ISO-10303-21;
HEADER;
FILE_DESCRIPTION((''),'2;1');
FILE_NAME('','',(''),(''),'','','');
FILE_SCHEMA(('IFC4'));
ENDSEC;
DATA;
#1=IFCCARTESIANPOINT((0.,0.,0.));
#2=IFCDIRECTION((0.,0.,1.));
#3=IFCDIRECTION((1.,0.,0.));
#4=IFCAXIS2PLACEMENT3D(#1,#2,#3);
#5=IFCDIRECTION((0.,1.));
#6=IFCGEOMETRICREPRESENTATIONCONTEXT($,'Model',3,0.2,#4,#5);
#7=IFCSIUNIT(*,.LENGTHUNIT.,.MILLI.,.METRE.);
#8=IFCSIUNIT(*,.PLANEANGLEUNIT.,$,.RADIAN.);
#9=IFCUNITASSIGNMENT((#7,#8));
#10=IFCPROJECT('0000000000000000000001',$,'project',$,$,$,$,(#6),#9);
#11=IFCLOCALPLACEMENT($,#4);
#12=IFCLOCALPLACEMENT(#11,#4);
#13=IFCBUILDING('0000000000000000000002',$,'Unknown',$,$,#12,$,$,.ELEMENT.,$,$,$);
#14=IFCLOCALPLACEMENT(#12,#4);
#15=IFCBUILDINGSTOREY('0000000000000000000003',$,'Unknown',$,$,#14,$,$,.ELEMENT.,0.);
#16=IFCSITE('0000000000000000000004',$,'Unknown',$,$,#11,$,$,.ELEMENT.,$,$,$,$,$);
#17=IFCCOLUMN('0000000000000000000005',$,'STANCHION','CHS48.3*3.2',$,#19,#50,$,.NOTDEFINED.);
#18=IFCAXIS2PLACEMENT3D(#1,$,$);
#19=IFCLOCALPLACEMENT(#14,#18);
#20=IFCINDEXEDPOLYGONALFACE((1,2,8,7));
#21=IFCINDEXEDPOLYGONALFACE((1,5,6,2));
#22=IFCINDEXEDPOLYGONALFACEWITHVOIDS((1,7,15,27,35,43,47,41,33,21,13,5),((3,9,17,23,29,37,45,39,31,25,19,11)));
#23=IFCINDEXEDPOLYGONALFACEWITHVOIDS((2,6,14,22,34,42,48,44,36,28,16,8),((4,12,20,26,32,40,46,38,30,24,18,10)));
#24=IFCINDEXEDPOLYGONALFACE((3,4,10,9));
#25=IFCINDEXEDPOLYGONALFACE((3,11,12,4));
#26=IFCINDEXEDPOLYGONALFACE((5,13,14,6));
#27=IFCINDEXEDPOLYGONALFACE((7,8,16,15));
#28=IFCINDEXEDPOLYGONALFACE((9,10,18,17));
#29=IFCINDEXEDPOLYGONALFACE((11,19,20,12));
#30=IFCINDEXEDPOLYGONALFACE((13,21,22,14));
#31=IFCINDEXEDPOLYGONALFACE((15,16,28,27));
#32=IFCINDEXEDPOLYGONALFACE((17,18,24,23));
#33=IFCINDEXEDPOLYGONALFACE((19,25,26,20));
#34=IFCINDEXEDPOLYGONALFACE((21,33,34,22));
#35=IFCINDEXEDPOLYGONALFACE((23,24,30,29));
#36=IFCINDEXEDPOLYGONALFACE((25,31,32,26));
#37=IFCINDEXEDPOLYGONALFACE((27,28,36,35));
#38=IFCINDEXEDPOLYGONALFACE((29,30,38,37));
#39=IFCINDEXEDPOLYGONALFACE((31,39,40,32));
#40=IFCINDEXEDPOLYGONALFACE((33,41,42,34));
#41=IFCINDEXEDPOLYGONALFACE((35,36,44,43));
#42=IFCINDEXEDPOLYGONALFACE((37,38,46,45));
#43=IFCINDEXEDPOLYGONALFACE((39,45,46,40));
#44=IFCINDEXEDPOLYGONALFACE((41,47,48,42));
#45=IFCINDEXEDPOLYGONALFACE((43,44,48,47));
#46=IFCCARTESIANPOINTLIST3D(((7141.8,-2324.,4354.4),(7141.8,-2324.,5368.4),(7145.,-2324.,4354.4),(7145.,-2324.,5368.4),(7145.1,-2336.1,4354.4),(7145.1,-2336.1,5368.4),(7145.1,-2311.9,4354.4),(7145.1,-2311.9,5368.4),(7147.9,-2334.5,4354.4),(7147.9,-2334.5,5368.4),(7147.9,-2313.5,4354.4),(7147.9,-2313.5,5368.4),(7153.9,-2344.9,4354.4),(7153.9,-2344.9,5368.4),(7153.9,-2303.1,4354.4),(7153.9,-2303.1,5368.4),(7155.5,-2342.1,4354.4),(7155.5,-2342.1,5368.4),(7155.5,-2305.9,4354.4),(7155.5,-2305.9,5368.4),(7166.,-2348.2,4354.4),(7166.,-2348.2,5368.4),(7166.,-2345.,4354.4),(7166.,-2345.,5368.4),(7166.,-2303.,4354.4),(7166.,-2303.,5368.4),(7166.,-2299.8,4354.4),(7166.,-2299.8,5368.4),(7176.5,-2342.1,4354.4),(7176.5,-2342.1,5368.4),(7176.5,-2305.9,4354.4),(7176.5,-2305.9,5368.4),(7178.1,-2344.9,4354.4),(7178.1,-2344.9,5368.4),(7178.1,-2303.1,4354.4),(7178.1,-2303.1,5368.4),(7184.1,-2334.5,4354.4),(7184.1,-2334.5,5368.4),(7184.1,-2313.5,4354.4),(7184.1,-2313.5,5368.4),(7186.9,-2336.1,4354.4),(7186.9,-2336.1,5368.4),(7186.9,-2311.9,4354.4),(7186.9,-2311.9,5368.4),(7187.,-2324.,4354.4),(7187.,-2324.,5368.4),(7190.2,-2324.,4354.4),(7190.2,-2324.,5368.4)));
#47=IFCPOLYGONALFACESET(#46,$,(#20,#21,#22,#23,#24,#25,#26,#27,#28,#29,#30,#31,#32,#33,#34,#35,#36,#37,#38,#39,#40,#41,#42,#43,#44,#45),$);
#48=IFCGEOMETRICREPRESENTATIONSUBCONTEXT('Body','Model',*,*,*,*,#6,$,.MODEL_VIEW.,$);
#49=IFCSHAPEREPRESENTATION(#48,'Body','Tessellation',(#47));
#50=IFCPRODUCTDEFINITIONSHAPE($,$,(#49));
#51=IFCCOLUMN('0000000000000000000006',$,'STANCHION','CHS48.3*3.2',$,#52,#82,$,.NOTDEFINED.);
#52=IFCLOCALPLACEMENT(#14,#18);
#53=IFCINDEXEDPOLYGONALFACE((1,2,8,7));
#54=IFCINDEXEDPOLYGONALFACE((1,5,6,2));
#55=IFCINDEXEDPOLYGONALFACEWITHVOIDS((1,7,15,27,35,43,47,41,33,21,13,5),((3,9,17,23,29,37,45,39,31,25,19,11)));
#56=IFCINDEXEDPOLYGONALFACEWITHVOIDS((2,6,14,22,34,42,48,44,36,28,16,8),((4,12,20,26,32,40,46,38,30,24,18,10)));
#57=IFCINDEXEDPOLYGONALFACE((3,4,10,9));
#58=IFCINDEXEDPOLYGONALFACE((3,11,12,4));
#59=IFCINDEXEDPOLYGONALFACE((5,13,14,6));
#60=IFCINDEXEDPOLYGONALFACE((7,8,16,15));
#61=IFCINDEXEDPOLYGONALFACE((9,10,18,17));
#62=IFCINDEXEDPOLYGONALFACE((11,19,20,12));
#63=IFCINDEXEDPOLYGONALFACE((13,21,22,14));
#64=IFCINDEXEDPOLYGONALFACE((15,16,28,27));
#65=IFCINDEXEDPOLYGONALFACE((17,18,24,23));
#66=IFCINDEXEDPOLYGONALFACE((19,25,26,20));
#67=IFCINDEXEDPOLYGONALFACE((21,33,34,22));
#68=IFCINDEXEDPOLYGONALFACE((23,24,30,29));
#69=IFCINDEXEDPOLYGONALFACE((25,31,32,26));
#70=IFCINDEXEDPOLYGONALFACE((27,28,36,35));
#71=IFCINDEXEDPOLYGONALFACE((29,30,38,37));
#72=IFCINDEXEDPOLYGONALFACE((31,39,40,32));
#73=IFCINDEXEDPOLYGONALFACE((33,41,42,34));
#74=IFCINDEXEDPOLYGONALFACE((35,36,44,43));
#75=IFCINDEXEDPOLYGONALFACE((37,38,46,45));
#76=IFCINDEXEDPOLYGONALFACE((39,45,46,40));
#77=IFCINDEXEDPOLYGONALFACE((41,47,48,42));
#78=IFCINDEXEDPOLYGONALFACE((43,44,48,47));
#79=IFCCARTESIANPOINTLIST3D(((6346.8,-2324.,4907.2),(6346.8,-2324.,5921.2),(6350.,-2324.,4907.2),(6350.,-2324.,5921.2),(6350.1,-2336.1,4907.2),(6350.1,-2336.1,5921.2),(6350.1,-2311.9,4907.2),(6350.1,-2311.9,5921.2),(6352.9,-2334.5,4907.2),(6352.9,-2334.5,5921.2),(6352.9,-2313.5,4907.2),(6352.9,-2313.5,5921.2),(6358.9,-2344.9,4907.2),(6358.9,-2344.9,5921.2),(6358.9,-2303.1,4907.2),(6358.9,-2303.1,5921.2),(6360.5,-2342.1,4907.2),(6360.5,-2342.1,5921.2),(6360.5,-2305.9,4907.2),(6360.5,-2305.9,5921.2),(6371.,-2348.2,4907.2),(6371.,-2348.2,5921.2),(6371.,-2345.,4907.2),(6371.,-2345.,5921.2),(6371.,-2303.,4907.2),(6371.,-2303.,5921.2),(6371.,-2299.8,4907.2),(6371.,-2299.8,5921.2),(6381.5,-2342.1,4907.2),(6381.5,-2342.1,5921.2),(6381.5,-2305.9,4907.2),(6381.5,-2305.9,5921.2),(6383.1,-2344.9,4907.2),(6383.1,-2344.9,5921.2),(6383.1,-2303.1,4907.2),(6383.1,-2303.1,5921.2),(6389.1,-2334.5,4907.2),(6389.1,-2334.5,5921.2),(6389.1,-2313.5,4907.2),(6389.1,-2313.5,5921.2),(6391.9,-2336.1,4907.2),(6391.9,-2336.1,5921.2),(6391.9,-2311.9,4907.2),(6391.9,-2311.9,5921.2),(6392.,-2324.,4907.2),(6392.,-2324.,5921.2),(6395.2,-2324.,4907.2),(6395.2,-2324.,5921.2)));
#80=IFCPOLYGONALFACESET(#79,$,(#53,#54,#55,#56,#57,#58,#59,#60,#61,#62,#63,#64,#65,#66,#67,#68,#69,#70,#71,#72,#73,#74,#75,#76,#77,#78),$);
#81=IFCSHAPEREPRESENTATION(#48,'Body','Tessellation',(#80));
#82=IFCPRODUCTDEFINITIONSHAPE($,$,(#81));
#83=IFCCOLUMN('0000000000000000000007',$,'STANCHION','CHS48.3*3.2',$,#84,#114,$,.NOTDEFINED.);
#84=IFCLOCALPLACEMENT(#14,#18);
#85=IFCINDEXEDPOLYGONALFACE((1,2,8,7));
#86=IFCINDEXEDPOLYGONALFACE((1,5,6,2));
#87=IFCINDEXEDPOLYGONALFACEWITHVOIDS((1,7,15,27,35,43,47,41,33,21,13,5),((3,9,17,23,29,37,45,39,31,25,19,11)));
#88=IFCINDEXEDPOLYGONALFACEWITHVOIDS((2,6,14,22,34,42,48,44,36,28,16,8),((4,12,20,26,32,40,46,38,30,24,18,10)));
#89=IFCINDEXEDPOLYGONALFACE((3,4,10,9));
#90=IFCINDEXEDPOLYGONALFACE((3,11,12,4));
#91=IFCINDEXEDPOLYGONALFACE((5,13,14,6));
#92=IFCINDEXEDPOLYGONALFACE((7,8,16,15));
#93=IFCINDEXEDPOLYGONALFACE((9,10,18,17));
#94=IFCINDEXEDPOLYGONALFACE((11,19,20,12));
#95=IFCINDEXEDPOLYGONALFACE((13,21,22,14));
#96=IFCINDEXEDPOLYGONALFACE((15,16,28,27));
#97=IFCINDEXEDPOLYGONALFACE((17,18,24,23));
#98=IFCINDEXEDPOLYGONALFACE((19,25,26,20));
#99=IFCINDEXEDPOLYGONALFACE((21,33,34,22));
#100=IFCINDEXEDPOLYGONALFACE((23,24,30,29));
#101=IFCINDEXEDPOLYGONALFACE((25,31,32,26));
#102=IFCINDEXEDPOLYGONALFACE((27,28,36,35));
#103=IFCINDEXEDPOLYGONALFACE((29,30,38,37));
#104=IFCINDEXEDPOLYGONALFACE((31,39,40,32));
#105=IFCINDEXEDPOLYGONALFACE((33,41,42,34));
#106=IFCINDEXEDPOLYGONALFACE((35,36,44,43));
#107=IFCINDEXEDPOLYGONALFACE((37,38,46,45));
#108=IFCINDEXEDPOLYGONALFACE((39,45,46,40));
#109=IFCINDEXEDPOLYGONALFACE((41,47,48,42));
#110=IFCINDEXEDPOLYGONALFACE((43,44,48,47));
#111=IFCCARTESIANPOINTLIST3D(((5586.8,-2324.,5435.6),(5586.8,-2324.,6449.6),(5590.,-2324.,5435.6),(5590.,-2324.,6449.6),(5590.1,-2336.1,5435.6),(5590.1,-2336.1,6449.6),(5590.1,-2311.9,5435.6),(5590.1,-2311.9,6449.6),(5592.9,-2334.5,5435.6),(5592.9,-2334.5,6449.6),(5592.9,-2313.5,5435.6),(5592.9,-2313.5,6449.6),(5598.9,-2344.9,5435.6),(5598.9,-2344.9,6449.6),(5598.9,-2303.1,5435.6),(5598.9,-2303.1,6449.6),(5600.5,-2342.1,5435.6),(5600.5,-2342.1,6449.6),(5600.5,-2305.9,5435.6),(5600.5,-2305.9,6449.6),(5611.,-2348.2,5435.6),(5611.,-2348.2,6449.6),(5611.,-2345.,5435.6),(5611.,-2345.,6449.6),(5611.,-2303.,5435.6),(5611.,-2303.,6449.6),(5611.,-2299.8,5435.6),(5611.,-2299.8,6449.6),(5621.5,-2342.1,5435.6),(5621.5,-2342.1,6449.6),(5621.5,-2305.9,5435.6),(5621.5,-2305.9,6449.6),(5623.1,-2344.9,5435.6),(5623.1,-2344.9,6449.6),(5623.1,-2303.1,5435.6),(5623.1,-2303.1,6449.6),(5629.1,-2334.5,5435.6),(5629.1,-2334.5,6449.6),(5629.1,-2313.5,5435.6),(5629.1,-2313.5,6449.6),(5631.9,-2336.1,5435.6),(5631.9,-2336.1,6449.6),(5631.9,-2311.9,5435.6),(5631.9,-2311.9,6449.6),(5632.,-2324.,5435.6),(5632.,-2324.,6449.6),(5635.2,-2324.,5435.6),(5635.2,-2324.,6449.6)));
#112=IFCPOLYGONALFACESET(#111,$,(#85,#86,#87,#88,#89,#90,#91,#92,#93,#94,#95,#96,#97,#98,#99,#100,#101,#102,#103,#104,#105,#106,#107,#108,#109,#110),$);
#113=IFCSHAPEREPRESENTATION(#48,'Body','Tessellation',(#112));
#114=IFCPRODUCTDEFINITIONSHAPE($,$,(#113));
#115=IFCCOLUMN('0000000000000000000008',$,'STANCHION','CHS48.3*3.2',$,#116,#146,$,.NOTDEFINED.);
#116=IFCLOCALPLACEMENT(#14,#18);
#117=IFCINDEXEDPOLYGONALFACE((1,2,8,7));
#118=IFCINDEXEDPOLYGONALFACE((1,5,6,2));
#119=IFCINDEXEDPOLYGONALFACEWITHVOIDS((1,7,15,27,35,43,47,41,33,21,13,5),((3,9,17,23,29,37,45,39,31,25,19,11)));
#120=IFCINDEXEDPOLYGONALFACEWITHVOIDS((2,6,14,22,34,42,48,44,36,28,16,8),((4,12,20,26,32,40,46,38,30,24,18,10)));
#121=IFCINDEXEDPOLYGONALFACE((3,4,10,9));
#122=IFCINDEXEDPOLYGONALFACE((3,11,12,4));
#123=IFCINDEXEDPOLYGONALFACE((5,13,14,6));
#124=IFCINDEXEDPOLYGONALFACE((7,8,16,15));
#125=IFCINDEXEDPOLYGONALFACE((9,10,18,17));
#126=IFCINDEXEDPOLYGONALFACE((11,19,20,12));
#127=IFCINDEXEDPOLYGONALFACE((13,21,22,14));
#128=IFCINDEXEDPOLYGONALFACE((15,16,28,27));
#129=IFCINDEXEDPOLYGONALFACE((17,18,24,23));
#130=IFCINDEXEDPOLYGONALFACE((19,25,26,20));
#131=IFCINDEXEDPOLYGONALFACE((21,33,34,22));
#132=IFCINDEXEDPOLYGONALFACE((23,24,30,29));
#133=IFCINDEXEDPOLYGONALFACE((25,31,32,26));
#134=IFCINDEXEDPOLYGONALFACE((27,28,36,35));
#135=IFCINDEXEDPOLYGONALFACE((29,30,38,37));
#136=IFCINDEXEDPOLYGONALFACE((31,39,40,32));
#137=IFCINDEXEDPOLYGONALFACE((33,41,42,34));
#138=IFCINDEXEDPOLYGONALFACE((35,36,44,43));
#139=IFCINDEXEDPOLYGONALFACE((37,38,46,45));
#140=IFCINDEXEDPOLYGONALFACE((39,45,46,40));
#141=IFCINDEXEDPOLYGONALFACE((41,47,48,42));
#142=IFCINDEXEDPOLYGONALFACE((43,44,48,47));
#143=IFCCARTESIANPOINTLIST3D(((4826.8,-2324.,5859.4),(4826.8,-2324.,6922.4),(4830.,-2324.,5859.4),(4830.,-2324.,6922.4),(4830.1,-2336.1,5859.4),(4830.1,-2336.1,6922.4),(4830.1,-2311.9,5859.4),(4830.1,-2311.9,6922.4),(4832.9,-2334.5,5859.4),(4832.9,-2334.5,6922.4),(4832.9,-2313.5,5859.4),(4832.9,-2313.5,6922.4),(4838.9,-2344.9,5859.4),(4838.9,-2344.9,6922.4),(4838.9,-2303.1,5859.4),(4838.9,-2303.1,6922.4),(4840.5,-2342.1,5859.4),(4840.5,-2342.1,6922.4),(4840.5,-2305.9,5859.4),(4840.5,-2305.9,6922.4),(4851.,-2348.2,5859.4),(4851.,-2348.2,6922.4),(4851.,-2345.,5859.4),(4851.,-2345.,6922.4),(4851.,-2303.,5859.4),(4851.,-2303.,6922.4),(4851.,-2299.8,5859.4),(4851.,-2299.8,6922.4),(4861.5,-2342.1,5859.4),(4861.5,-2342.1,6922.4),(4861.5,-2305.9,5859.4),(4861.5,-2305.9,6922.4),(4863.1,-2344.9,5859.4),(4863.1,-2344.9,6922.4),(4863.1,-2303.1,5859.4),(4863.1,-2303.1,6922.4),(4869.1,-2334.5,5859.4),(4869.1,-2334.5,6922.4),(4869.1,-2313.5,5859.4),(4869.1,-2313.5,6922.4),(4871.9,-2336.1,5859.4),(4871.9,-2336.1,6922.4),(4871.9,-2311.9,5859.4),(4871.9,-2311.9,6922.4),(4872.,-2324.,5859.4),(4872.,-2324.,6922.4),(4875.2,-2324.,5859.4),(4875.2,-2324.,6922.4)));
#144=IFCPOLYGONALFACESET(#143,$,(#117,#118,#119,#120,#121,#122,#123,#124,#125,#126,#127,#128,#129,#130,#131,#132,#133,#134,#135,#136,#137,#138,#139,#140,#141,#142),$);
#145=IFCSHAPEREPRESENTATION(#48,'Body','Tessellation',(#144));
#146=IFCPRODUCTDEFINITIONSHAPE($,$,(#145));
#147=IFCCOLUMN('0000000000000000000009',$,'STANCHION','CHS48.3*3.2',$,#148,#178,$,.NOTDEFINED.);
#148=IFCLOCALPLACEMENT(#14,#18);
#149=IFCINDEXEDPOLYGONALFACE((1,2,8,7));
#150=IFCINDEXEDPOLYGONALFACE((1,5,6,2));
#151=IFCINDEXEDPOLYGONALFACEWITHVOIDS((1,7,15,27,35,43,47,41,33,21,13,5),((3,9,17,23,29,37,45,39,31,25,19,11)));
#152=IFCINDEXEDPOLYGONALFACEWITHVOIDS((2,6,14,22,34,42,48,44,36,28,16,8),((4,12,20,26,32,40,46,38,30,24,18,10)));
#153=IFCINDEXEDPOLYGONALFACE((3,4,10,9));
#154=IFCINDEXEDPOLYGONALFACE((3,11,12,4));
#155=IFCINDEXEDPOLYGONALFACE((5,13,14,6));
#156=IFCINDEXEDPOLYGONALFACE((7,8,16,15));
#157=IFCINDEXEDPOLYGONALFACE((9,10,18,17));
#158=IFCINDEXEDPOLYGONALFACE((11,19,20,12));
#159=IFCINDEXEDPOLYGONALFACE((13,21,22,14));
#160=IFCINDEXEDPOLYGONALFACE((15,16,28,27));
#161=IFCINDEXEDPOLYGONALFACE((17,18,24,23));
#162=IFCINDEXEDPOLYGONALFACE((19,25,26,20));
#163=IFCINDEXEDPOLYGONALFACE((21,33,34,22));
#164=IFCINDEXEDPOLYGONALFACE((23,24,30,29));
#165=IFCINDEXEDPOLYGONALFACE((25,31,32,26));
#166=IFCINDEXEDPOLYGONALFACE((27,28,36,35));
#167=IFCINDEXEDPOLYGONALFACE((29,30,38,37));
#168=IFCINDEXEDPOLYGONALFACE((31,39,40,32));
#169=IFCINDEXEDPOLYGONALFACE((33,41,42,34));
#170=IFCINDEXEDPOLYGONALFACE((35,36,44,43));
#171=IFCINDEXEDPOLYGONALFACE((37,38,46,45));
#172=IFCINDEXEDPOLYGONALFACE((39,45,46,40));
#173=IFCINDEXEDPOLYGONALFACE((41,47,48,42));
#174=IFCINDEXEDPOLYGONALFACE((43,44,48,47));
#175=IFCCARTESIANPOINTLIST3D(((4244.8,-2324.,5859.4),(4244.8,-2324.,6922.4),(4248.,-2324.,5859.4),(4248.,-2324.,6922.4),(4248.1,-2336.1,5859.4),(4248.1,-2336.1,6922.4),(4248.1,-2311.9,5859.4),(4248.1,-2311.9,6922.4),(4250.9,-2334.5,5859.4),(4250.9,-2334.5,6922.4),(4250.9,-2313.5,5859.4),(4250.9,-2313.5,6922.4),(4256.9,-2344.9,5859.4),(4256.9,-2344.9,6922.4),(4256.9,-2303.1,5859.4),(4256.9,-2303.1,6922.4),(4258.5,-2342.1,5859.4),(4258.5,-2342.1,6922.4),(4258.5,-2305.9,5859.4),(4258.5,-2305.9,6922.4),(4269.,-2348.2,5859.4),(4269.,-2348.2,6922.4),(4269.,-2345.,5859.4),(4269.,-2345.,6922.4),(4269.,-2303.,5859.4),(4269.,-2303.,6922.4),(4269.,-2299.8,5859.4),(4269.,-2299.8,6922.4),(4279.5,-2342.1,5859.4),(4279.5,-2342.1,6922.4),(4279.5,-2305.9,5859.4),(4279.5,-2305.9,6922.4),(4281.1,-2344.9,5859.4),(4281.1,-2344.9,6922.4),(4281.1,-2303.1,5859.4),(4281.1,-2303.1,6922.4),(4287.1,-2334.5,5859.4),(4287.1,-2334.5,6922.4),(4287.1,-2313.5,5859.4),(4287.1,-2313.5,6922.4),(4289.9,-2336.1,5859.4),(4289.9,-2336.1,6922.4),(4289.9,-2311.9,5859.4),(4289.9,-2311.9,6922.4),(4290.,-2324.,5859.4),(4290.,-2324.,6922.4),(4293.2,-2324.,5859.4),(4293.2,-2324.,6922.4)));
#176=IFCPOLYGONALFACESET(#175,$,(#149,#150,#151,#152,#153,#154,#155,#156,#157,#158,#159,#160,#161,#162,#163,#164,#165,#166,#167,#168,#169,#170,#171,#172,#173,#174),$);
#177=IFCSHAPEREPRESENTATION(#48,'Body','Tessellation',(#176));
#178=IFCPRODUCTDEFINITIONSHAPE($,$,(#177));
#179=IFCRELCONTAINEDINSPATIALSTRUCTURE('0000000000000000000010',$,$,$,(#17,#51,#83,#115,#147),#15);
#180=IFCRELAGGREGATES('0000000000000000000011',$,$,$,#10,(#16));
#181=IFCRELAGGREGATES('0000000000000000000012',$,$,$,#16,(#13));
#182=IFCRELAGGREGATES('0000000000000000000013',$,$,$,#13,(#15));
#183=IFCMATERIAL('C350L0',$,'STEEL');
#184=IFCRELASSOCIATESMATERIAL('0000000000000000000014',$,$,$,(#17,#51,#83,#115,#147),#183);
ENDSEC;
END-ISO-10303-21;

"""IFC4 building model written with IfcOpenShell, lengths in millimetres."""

from ifc_helpers import new_model, si_unit, direction, frame, origin_with_axes, place, context, subcontext, project, spatial, line, indexed_curve, outline, extrude, material, element, save


model = new_model("IFC4")

# Units and contexts
model_context = context("Model", 3, precision=0.2, world=origin_with_axes(), true_north=direction((0.0, 1.0)))
body_context = subcontext(model_context, "Body", "Model", "MODEL_VIEW")
ifc_project = project(units=[si_unit("LENGTHUNIT", "METRE", prefix="MILLI"), si_unit("PLANEANGLEUNIT", "RADIAN")], contexts=[model_context])

# Site, building, storey
site_placement = place(None, origin_with_axes())
site = spatial("IfcSite", under=ifc_project, at=site_placement, Name="Unknown", CompositionType="ELEMENT")
building_placement = place(site_placement, origin_with_axes())
building = spatial("IfcBuilding", under=site, at=building_placement, Name="Unknown", CompositionType="ELEMENT")
storey_placement = place(building_placement, origin_with_axes())
storey = spatial("IfcBuildingStorey", under=building, at=storey_placement, Name="Unknown", CompositionType="ELEMENT", Elevation=0.0)

# Columns
ifc_material_1 = material(Name="C350L0", Category="STEEL")
for number, where, z_axis, x_axis, name in (
    (1, (7166.0, -2324.0, 4354.4), (-1.0, 0.0, 0.0), (0.0, 0.0, 1.0), "STANCHION"),
    (2, (6371.0, -2324.0, 4907.2), (-1.0, 0.0, 0.0), (0.0, 0.0, 1.0), "STANCHION"),
    (3, (5611.0, -2324.0, 5435.6), (-1.0, 0.0, 0.0), (0.0, 0.0, 1.0), "STANCHION"),
):
    element("IfcColumn", number, at=place(storey_placement, frame(where, z_axis=z_axis, x_axis=x_axis)), inside=storey, material=ifc_material_1, Name=name, Description="CHS48.3*3.2", PredefinedType="NOTDEFINED", context=body_context, shape_type="SolidModel", body=[
        extrude(outline(indexed_curve([(24.1, 0.0), (20.9, 12.1), (12.1, 20.9), (0.0, 24.1), (-12.1, 20.9), (-20.9, 12.1), (-24.1, 0.0), (-20.9, -12.1), (-12.1, -20.9), (0.0, -24.1), (12.1, -20.9), (20.9, -12.1)], segments=[line(1, 2, 3, 4, 5, 6, 7, 8, 9, 10, 11, 12, 1)]), holes=[indexed_curve([(20.9, 0.0), (18.1, -10.5), (10.5, -18.1), (0.0, -20.9), (-10.5, -18.1), (-18.1, -10.5), (-20.9, 0.0), (-18.1, 10.5), (-10.5, 18.1), (0.0, 20.9), (10.5, 18.1), (18.1, 10.5)], segments=[line(1, 2, 3, 4, 5, 6, 7, 8, 9, 10, 11, 12, 1)])]), frame((0.0, 0.0, 0.0), z_axis=(-1.0, 0.0, 0.0), x_axis=(0.0, 0.0, 1.0)), (0.0, 0.0, -1.0), 1014.0),
    ])
for number, where, z_axis, x_axis, name in (
    (4, (4851.0, -2324.0, 5859.4), (-1.0, 0.0, 0.0), (0.0, 0.0, 1.0), "STANCHION"),
    (5, (4269.0, -2324.0, 5859.4), (-1.0, 0.0, 0.0), (0.0, 0.0, 1.0), "STANCHION"),
):
    element("IfcColumn", number, at=place(storey_placement, frame(where, z_axis=z_axis, x_axis=x_axis)), inside=storey, material=ifc_material_1, Name=name, Description="CHS48.3*3.2", PredefinedType="NOTDEFINED", context=body_context, shape_type="SolidModel", body=[
        extrude(outline(indexed_curve([(24.1, 0.0), (20.9, 12.1), (12.1, 20.9), (0.0, 24.1), (-12.1, 20.9), (-20.9, 12.1), (-24.1, 0.0), (-20.9, -12.1), (-12.1, -20.9), (0.0, -24.1), (12.1, -20.9), (20.9, -12.1)], segments=[line(1, 2, 3, 4, 5, 6, 7, 8, 9, 10, 11, 12, 1)]), holes=[indexed_curve([(20.9, 0.0), (18.1, -10.5), (10.5, -18.1), (0.0, -20.9), (-10.5, -18.1), (-18.1, -10.5), (-20.9, 0.0), (-18.1, 10.5), (-10.5, 18.1), (0.0, 20.9), (10.5, 18.1), (18.1, 10.5)], segments=[line(1, 2, 3, 4, 5, 6, 7, 8, 9, 10, 11, 12, 1)])]), frame((0.0, 0.0, 0.0), z_axis=(-1.0, 0.0, 0.0), x_axis=(0.0, 0.0, 1.0)), (0.0, 0.0, -1.0), 1063.0),
    ])

save(model, "model.ifc")
